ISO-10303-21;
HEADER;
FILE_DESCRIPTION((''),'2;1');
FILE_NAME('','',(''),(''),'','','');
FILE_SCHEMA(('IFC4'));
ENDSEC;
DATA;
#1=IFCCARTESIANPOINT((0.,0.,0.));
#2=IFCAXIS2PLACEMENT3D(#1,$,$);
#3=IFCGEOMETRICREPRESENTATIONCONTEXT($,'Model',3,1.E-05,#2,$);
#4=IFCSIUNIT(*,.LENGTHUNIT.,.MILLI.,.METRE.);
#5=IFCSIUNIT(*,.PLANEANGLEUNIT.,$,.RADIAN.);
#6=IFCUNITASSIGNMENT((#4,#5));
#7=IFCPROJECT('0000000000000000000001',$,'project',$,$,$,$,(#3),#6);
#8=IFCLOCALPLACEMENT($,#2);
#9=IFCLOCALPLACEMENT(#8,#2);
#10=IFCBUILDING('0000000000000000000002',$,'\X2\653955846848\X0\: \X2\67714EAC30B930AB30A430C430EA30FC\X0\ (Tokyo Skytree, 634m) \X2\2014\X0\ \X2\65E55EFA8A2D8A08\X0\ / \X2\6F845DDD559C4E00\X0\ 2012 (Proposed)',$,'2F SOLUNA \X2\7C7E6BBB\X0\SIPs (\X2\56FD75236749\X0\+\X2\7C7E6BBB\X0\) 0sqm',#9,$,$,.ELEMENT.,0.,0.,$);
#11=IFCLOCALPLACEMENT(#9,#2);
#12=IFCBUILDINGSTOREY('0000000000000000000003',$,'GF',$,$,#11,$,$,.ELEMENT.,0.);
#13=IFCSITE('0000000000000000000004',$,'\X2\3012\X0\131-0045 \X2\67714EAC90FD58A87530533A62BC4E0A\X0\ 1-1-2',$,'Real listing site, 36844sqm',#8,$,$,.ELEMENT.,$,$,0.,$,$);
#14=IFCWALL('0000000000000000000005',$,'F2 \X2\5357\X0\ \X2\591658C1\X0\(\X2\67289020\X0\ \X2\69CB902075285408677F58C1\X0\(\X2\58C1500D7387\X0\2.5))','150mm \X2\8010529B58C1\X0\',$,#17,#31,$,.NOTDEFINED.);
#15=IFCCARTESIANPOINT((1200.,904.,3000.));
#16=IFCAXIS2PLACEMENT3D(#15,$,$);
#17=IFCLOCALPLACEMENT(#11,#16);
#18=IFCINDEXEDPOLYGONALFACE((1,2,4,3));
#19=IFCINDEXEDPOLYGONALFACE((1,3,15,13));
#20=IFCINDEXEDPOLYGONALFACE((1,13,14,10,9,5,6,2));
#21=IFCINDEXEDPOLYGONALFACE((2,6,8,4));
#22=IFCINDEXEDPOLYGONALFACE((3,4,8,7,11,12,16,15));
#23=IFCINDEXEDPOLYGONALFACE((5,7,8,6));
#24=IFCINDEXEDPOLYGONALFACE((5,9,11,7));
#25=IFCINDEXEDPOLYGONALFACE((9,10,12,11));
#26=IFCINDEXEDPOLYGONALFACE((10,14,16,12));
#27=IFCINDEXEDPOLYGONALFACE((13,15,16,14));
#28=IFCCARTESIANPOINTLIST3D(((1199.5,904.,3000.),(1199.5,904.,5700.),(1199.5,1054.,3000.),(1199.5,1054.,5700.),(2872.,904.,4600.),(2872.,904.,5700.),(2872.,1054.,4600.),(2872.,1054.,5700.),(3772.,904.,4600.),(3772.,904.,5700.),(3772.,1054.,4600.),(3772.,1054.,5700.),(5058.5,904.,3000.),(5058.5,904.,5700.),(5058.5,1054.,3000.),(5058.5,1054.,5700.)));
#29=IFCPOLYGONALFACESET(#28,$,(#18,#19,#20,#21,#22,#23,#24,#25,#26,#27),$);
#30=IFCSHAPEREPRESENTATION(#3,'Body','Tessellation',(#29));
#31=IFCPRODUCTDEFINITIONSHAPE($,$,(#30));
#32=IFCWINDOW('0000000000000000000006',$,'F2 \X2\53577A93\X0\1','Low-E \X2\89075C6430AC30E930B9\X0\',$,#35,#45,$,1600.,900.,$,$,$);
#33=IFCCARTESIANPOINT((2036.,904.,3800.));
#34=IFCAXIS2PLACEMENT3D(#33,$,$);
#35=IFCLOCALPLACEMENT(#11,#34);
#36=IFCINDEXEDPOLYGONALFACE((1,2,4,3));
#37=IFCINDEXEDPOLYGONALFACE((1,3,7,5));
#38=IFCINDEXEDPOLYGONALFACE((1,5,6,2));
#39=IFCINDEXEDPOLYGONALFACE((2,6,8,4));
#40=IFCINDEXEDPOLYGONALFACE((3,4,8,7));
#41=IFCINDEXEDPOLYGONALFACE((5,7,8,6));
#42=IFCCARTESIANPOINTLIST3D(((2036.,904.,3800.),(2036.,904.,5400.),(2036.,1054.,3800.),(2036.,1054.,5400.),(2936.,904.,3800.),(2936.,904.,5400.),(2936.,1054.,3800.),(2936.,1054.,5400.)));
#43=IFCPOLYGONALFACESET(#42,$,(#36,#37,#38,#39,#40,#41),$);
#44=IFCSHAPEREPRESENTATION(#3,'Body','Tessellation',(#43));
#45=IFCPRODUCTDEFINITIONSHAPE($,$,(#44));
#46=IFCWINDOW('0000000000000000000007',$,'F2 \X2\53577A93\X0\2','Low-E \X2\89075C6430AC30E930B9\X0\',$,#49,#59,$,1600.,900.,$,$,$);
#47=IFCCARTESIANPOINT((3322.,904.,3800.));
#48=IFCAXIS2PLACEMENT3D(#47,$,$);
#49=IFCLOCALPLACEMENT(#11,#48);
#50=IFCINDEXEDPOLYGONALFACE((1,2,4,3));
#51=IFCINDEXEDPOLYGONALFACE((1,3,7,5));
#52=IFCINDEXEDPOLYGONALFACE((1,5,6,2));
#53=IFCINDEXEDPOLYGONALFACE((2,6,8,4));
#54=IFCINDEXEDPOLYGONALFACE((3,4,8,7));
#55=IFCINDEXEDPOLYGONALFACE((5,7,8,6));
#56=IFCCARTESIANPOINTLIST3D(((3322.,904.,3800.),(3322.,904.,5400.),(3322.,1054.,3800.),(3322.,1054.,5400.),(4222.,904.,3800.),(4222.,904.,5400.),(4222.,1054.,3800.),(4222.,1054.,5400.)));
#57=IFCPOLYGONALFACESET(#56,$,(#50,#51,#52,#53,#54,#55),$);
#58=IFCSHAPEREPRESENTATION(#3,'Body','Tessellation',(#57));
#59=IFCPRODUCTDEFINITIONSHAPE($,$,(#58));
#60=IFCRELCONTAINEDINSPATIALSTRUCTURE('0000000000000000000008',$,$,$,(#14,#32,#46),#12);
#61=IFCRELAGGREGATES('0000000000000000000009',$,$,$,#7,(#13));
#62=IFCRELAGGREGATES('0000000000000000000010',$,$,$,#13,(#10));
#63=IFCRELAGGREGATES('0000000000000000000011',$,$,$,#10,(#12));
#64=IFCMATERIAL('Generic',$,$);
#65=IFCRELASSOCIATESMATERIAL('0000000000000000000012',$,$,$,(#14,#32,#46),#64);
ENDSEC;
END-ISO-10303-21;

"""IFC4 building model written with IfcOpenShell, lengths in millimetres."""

from ifc_helpers import new_model, si_unit, frame, frame_2d, origin, place, context, project, spatial, rectangle, extrude, material, element, fill, save


model = new_model("IFC4")

# Units and contexts
model_context = context("Model", 3, precision=1e-05, world=origin())
ifc_project = project(units=[si_unit("LENGTHUNIT", "METRE", prefix="MILLI"), si_unit("PLANEANGLEUNIT", "RADIAN")], contexts=[model_context])

# Site, building, storey
site_placement = place(None, origin())
site = spatial("IfcSite", under=ifc_project, at=site_placement, Name="〒131-0045 東京都墨田区押上 1-1-2", ObjectType="Real listing site, 36844sqm", CompositionType="ELEMENT", RefElevation=0.0)
building_placement = place(site_placement, origin())
building = spatial("IfcBuilding", under=site, at=building_placement, Name="改善案: 東京スカイツリー (Tokyo Skytree, 634m) — 日建設計 / 澄川喜一 2012 (Proposed)", ObjectType="2F SOLUNA 籾殻SIPs (国産杉+籾殻) 0sqm", CompositionType="ELEMENT", ElevationOfRefHeight=0.0, ElevationOfTerrain=0.0)
storey_placement = place(building_placement, origin())
storey = spatial("IfcBuildingStorey", under=building, at=storey_placement, Name="GF", CompositionType="ELEMENT", Elevation=0.0)

# Shared definitions
ifc_material_1 = material(Name="Generic")

# Wall, openings, windows
wall_1_placement = place(storey_placement, frame((1200.0, 904.0, 3000.0)))
wall_1 = element("IfcWall", 1, at=wall_1_placement, inside=storey, material=ifc_material_1, Name="F2 南 外壁(木造 構造用合板壁(壁倍率2.5))", Description="150mm 耐力壁", PredefinedType="NOTDEFINED", context=model_context, shape_type="SweptSolid", body=[
    extrude(rectangle(XDim=3859.0, YDim=150.0, at=frame_2d((1929.0, 75.0))), frame((1200.0, 904.0, 3000.0)), (0.0, 0.0, 1.0), 2700.0),
])
opening_1_placement = place(storey_placement, frame((2036.0, 904.0, 3800.0)))
opening_1 = element("IfcOpeningElement", 2, at=opening_1_placement, cuts=wall_1, PredefinedType="NOTDEFINED", context=model_context, shape_type="SweptSolid", body=[
    extrude(rectangle(XDim=900.0, YDim=150.0, at=frame_2d((450.0, 75.0))), frame((2036.0, 904.0, 3800.0)), (0.0, 0.0, 1.0), 1600.0),
])
opening_2_placement = place(storey_placement, frame((3322.0, 904.0, 3800.0)))
opening_2 = element("IfcOpeningElement", 3, at=opening_2_placement, cuts=wall_1, PredefinedType="NOTDEFINED", context=model_context, shape_type="SweptSolid", body=[
    extrude(rectangle(XDim=900.0, YDim=150.0, at=frame_2d((450.0, 75.0))), frame((3322.0, 904.0, 3800.0)), (0.0, 0.0, 1.0), 1600.0),
])
window_1_placement = place(storey_placement, frame((2036.0, 904.0, 3800.0)))
window_1 = element("IfcWindow", 4, at=window_1_placement, inside=storey, material=ifc_material_1, Name="F2 南窓1", Description="Low-E 複層ガラス", OverallHeight=1600.0, OverallWidth=900.0, context=model_context, shape_type="SweptSolid", body=[
    extrude(rectangle(XDim=900.0, YDim=150.0, at=frame_2d((450.0, 75.0))), frame((2036.0, 904.0, 3800.0)), (0.0, 0.0, 1.0), 1600.0),
])
fill(opening_1, window_1)
window_2_placement = place(storey_placement, frame((3322.0, 904.0, 3800.0)))
window_2 = element("IfcWindow", 5, at=window_2_placement, inside=storey, material=ifc_material_1, Name="F2 南窓2", Description="Low-E 複層ガラス", OverallHeight=1600.0, OverallWidth=900.0, context=model_context, shape_type="SweptSolid", body=[
    extrude(rectangle(XDim=900.0, YDim=150.0, at=frame_2d((450.0, 75.0))), frame((3322.0, 904.0, 3800.0)), (0.0, 0.0, 1.0), 1600.0),
])
fill(opening_2, window_2)

save(model, "model.ifc")
